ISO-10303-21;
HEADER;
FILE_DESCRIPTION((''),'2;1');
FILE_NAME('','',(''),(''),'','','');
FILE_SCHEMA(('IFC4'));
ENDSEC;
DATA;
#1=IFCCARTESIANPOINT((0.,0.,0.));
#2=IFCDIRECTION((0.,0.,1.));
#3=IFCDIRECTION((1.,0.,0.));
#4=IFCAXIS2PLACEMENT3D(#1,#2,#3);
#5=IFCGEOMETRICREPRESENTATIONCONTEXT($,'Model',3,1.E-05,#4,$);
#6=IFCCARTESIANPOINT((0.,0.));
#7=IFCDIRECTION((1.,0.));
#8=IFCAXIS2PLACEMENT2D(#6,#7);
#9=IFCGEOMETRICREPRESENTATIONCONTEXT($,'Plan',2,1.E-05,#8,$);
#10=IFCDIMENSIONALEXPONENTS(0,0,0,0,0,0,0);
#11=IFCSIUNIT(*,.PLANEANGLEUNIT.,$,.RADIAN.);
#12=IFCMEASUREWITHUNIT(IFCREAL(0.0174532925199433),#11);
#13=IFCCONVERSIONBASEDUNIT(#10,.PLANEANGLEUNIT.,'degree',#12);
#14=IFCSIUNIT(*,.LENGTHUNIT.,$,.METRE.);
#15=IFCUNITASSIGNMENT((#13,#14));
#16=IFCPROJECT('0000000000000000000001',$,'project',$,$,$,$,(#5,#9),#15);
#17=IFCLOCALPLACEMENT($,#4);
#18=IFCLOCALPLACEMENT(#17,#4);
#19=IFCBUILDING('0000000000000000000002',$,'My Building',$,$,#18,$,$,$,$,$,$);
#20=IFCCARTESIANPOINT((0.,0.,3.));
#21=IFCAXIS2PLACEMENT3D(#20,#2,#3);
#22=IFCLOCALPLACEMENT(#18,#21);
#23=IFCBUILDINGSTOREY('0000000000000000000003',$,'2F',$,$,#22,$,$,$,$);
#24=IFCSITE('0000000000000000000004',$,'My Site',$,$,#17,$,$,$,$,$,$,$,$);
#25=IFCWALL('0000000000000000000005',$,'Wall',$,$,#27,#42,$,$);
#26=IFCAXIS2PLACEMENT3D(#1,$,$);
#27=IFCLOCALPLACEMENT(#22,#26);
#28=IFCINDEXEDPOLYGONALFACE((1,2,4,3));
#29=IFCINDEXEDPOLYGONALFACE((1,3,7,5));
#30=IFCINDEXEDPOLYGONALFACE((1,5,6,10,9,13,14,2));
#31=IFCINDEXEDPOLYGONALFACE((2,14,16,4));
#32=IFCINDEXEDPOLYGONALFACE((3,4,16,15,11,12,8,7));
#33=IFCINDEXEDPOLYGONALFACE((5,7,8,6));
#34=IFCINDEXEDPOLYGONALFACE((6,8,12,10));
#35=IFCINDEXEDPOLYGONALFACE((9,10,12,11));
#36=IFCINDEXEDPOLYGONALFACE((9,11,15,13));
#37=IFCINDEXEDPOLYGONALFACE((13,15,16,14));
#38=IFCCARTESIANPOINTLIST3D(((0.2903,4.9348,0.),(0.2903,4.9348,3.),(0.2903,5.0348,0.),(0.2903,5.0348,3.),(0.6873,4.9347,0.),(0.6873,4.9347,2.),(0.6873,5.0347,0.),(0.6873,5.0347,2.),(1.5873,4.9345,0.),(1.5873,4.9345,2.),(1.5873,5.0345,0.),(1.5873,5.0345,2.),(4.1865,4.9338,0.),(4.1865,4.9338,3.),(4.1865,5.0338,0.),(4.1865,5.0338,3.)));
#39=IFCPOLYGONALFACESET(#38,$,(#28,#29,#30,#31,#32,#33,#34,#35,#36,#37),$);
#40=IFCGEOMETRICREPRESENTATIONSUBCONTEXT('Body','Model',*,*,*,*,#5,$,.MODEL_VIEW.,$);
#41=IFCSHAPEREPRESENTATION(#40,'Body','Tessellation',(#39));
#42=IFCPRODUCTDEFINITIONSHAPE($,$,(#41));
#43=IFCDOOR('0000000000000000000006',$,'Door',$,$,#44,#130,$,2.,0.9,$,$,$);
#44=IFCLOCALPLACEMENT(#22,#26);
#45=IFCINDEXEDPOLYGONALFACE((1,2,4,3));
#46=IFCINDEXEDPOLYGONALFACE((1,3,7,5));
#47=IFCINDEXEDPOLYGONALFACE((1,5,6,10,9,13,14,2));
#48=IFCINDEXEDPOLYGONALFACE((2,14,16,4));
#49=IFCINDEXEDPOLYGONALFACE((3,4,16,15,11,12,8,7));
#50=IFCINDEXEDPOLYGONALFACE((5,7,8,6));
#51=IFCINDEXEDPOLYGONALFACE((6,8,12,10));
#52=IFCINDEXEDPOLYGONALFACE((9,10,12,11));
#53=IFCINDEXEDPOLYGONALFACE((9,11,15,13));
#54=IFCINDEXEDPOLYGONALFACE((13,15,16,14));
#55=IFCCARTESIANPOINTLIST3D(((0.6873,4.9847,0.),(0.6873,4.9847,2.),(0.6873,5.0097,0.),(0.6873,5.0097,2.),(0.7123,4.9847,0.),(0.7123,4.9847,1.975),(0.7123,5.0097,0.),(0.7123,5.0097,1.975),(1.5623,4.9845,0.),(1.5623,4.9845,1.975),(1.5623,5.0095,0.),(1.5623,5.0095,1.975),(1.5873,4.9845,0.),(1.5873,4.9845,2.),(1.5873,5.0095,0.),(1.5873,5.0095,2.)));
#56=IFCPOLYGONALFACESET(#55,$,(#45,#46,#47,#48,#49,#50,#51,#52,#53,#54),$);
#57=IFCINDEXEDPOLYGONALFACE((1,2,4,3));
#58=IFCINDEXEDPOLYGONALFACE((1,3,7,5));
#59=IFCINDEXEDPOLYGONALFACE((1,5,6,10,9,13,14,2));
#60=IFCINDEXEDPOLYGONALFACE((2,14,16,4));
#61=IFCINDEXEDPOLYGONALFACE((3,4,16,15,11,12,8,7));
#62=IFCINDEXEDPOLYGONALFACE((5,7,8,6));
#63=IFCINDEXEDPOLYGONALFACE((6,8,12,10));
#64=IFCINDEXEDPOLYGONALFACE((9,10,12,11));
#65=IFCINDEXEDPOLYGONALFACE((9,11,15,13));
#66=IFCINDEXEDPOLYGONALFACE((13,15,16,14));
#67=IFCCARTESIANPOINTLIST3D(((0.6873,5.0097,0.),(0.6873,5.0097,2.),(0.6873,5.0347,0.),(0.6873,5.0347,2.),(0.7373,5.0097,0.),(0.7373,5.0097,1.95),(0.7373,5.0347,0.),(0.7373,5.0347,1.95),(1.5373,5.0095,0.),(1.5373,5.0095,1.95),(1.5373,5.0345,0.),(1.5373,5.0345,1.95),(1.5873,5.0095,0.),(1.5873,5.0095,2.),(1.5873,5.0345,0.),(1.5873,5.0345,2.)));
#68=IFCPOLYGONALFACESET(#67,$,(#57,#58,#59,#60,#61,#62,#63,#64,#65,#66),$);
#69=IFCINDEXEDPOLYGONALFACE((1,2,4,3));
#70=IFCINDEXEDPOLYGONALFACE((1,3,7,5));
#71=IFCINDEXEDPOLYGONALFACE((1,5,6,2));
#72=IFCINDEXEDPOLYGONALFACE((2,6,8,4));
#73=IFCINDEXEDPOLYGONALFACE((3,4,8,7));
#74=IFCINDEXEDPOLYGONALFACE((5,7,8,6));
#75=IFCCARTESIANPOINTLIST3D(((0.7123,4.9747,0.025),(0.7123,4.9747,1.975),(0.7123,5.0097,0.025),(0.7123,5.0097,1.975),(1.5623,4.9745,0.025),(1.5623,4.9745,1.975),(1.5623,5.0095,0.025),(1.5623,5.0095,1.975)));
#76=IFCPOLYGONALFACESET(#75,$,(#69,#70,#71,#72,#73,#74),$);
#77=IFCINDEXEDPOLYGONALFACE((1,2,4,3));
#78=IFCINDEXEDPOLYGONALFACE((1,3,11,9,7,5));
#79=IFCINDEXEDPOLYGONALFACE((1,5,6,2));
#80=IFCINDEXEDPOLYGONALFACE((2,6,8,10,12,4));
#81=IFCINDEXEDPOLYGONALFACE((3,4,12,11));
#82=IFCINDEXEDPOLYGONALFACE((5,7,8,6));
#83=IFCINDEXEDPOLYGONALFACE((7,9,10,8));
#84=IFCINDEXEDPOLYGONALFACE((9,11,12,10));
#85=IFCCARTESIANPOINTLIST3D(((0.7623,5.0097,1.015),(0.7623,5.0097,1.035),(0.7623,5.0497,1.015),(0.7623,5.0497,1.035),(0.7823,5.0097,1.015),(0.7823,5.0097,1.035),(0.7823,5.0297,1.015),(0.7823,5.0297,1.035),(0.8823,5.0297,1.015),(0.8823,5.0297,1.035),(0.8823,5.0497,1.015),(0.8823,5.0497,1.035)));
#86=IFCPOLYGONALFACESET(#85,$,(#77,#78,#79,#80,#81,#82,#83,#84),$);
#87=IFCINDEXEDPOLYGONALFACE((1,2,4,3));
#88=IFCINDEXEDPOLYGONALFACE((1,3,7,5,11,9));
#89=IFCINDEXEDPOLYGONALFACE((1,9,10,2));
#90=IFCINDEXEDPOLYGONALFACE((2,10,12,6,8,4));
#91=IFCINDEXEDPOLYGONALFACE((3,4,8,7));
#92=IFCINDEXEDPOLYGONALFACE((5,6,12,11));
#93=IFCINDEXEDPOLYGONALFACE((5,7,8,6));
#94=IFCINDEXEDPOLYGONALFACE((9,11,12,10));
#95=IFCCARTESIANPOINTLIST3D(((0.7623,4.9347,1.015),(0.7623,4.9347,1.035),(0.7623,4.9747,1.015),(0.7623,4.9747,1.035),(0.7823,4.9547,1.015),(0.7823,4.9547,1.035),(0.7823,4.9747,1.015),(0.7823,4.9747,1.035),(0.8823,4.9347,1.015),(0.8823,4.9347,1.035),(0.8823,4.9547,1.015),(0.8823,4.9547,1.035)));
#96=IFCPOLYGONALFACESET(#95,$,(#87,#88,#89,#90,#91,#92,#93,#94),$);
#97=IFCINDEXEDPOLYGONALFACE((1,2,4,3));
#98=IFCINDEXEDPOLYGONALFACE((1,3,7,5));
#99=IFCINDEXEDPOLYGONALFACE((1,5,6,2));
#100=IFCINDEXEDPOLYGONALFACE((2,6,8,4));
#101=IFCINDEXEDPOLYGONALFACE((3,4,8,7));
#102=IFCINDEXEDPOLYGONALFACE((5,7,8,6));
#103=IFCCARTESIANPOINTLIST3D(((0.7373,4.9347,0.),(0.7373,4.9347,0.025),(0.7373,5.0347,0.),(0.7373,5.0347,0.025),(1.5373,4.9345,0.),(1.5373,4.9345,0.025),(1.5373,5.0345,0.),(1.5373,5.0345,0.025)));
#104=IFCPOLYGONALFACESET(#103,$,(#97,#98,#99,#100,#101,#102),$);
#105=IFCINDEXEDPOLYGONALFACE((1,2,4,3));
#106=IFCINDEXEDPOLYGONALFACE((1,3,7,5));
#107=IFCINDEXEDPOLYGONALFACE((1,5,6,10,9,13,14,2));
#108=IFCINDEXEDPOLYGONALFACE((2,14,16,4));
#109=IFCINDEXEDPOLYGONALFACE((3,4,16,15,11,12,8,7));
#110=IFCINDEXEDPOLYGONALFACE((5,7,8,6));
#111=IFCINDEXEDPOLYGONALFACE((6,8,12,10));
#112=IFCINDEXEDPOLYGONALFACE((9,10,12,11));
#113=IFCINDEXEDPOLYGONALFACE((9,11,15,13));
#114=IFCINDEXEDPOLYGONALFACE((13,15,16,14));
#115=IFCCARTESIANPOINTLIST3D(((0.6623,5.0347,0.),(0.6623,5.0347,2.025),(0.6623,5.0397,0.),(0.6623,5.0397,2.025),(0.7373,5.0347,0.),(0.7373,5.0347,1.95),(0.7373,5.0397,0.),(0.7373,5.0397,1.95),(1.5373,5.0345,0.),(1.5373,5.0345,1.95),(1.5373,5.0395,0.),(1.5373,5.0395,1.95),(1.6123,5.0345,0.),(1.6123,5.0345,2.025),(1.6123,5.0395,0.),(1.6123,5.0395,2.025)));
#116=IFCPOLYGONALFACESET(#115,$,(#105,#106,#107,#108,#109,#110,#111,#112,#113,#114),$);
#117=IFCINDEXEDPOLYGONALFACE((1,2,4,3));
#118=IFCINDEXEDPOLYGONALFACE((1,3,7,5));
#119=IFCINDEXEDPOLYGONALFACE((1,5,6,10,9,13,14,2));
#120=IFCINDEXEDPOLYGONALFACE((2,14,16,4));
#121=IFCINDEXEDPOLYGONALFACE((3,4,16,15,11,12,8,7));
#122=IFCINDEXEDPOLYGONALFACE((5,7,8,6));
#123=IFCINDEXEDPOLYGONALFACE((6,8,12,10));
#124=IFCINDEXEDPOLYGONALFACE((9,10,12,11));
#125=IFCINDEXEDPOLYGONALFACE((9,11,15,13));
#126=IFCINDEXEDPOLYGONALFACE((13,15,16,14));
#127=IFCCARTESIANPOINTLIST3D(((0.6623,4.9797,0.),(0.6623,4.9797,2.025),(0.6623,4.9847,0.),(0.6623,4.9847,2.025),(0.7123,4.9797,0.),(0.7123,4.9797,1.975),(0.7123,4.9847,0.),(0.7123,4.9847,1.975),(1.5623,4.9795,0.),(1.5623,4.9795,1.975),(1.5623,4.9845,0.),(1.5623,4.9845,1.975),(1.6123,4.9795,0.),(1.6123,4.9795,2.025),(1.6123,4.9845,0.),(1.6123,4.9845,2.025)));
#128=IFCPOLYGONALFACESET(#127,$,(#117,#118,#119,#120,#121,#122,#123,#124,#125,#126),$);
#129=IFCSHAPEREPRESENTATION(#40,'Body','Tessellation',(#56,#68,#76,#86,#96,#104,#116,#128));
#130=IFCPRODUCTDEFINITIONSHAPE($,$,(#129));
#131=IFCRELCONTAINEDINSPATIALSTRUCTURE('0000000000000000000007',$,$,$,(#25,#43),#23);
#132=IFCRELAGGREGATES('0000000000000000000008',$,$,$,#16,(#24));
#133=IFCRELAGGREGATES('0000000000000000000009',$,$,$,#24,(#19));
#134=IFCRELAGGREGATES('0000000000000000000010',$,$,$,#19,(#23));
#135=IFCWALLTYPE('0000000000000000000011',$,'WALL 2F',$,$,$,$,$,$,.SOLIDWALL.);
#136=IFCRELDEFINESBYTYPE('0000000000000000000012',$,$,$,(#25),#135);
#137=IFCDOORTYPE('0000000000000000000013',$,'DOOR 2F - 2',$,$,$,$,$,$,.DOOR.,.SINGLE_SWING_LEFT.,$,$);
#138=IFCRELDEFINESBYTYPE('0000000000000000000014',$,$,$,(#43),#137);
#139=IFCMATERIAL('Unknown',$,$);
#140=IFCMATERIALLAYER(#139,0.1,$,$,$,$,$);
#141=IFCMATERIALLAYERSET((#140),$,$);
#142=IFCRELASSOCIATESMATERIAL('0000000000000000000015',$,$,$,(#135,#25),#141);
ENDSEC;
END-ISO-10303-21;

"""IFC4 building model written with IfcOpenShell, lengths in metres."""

from ifc_helpers import new_model, entity, si_unit, converted_unit, frame, origin_with_axes, origin_2d_with_axis, place, context, subcontext, project, spatial, line, indexed_curve, outline, extrude, shape, source, transform, mapped, material, layer, layer_set, layer_usage, type_object, type_shapes, element, fill, save


model = new_model("IFC4")

# Units and contexts
model_context = context("Model", 3, precision=1e-05, world=origin_with_axes())
plan_context = context("Plan", 2, precision=1e-05, world=origin_2d_with_axis())
body_context_1 = subcontext(model_context, "Body", "Model", "MODEL_VIEW")
body_context_2 = subcontext(plan_context, "Body", "Plan", "PLAN_VIEW")
ifc_project = project(units=[converted_unit("PLANEANGLEUNIT", "degree", entity("IfcReal", 0.0174532925199433), si_unit("PLANEANGLEUNIT", "RADIAN"), dimensions=[0, 0, 0, 0, 0, 0, 0]), si_unit("LENGTHUNIT", "METRE")], contexts=[model_context, plan_context])

# Site, building, storey
site_placement = place(None, origin_with_axes())
site = spatial("IfcSite", under=ifc_project, at=site_placement, Name="My Site")
building_placement = place(site_placement, origin_with_axes())
building = spatial("IfcBuilding", under=site, at=building_placement, Name="My Building")
storey_placement = place(building_placement, frame((0.0, 0.0, 3.0), z_axis=(0.0, 0.0, 1.0), x_axis=(1.0, 0.0, 0.0)))
storey = spatial("IfcBuildingStorey", under=building, at=storey_placement, Name="2F")

# Shared definitions
ifc_material = material(Name="Unknown")

# Shared definitions
ifc_layer_1 = layer(ifc_material, 0.1)
ifc_layer_set_1 = layer_set([ifc_layer_1])
wall_type = type_object("IfcWallType", Name="WALL 2F", PredefinedType="SOLIDWALL", material=ifc_layer_set_1)

# Shared definitions
shared_shape_1 = source(origin_with_axes(), body_context_1, "Body", "SweptSolid", [
    extrude(outline(indexed_curve([(0.0, 0.0), (0.9, 0.0), (0.9, 2.0), (0.0, 2.0)], segments=[line(1, 2, 3, 4, 1)])), frame((0.0, -0.6, 0.0), z_axis=(0.0, -1.0, 0.0), x_axis=(1.0, 0.0, 0.0)), (0.0, 0.0, -1.0), 1.2),
])
door_type_1 = type_object("IfcDoorType", Name="DOOR 2F - 2", OperationType="SINGLE_SWING_LEFT", PredefinedType="DOOR")
shared_shape_2 = source(origin_with_axes(), body_context_1, "Body", "SweptSolid", [
    extrude(outline(indexed_curve([(0.0, 0.0), (0.0, 2.0), (0.9, 2.0), (0.9, 0.0), (0.875, 0.0), (0.875, 1.975), (0.025, 1.975), (0.025, 0.0)], segments=[line(1, 2, 3, 4, 5, 6, 7, 8, 1)])), frame((0.0, 0.025, 0.0), z_axis=(0.0, -1.0, 0.0), x_axis=(1.0, 0.0, 0.0)), (0.0, 0.0, -1.0), 0.025),
    extrude(outline(indexed_curve([(0.0, 0.0), (0.0, 2.0), (0.9, 2.0), (0.9, 0.0), (0.85, 0.0), (0.85, 1.95), (0.05, 1.95), (0.05, 0.0)], segments=[line(1, 2, 3, 4, 5, 6, 7, 8, 1)])), frame((0.0, 0.0, 0.0), z_axis=(0.0, -1.0, 0.0), x_axis=(1.0, 0.0, 0.0)), (0.0, 0.0, -1.0), 0.025),
    extrude(outline(indexed_curve([(0.0, 0.0), (0.85, 0.0), (0.85, 0.035), (0.0, 0.035)], segments=[line(1, 2, 3, 4, 1)])), frame((0.025, 0.025, 0.025), z_axis=(0.0, 0.0, 1.0), x_axis=(1.0, 0.0, 0.0)), (0.0, 0.0, 1.0), 1.95),
    extrude(outline(indexed_curve([(0.0, 0.0), (0.0, -0.04), (-0.12, -0.04), (-0.12, -0.02), (-0.02, -0.02), (-0.02, 0.0)], segments=[line(1, 2, 3, 4, 5, 6, 1)])), frame((0.825, 0.025, 1.015), z_axis=(0.0, 0.0, 1.0), x_axis=(1.0, 0.0, 0.0)), (0.0, 0.0, 1.0), 0.02),
    extrude(outline(indexed_curve([(0.0, 0.0), (0.0, 0.04), (-0.12, 0.04), (-0.12, 0.02), (-0.02, 0.02), (-0.02, 0.0)], segments=[line(1, 2, 3, 4, 5, 6, 1)])), frame((0.825, 0.06, 1.015), z_axis=(0.0, 0.0, 1.0), x_axis=(1.0, 0.0, 0.0)), (0.0, 0.0, 1.0), 0.02),
    extrude(outline(indexed_curve([(0.0, 0.0), (0.8, 0.0), (0.8, 0.1), (0.0, 0.1)], segments=[line(1, 2, 3, 4, 1)])), frame((0.05, 0.0, 0.0), z_axis=(0.0, 0.0, 1.0), x_axis=(1.0, 0.0, 0.0)), (0.0, 0.0, 1.0), 0.025),
    extrude(outline(indexed_curve([(0.0, 0.0), (0.0, 2.025), (0.95, 2.025), (0.95, 0.0), (0.875, 0.0), (0.875, 1.95), (0.075, 1.95), (0.075, 0.0)], segments=[line(1, 2, 3, 4, 5, 6, 7, 8, 1)])), frame((-0.025, -0.005, 0.0), z_axis=(0.0, -1.0, 0.0), x_axis=(1.0, 0.0, 0.0)), (0.0, 0.0, -1.0), 0.005),
    extrude(outline(indexed_curve([(0.0, 0.0), (0.0, 2.025), (0.95, 2.025), (0.95, 0.0), (0.9, 0.0), (0.9, 1.975), (0.05, 1.975), (0.05, 0.0)], segments=[line(1, 2, 3, 4, 5, 6, 7, 8, 1)])), frame((-0.025, 0.05, 0.0), z_axis=(0.0, -1.0, 0.0), x_axis=(1.0, 0.0, 0.0)), (0.0, 0.0, -1.0), 0.005),
])
shared_shape_3 = source(origin_with_axes(), body_context_2, "Body", "Curve2D", [
    entity("IfcIndexedPolyCurve", entity("IfcCartesianPointList2D", [[0.0, 0.0], [0.0, 0.05], [0.025, 0.05], [0.025, 0.025], [0.05, 0.025], [0.05, 0.0]]), [entity("IfcLineIndex", [1, 2, 3, 4, 5, 6, 1])]),
    entity("IfcIndexedPolyCurve", entity("IfcCartesianPointList2D", [[0.9, 0.0], [0.9, 0.05], [0.875, 0.05], [0.875, 0.025], [0.85, 0.025], [0.85, 0.0]]), [entity("IfcLineIndex", [1, 2, 3, 4, 5, 6, 1])]),
    entity("IfcTrimmedCurve", entity("IfcEllipse", entity("IfcAxis2Placement2D", entity("IfcCartesianPoint", [0.06, 0.05]), entity("IfcDirection", [1.0, 0.0])), 0.815, 0.85), [entity("IfcCartesianPoint", [0.875, 0.05])], [entity("IfcCartesianPoint", [0.06, 0.9])], True, "CARTESIAN"),
    entity("IfcIndexedPolyCurve", entity("IfcCartesianPointList2D", [[0.025, 0.05], [0.06, 0.05], [0.06, 0.9], [0.025, 0.9]]), [entity("IfcLineIndex", [1, 2, 3, 4, 1])]),
])
type_shapes(door_type_1, [shared_shape_2, shared_shape_3])

# Wall, opening, door
ifc_layer_usage_1 = layer_usage(ifc_layer_set_1, "AXIS2", "POSITIVE", 0.0)
wall_1_placement = place(storey_placement, frame((4.1865, 5.0338, 0.0), z_axis=(0.0, 0.0, 1.0), x_axis=(-1.0, 0.000249, 0.0)))
wall_1 = element("IfcWall", 1, at=wall_1_placement, inside=storey, type_object=wall_type, material=ifc_layer_usage_1, Name="Wall", context=body_context_1, shape_type="SweptSolid", body=[
    extrude(outline(indexed_curve([(0.0, 0.0), (0.0, 0.1), (3.8962, 0.1), (3.8962, 0.0)], segments=[line(1, 2, 3, 4, 1)])), origin_with_axes(), (0.0, 0.0, 1.0), 3.0),
])
opening_1_placement = place(wall_1_placement, frame((2.5992, 0.0, 0.0), z_axis=(0.0, 0.0, 1.0), x_axis=(1.0, 0.0, 0.0)))
opening_1 = element("IfcOpeningElement", 2, at=opening_1_placement, cuts=wall_1, PredefinedType="OPENING", context=body_context_1, shape_type="MappedRepresentation", body=[
    mapped(shared_shape_1, transform((0.0, 0.0, 0.0), x_axis=(1.0, 0.0, 0.0), y_axis=(0.0, 1.0, 0.0), z_axis=(0.0, 0.0, 1.0), scale=1.0)),
])
door_1_placement = place(opening_1_placement, frame((0.0, 0.0, 0.0), z_axis=(0.0, 0.0, 1.0), x_axis=(1.0, 0.0, 0.0)))
door_1 = element("IfcDoor", 3, at=door_1_placement, inside=storey, type_object=door_type_1, Name="Door", OverallHeight=2.0, OverallWidth=0.9, shapes=[
    shape(body_context_1, "Body", "MappedRepresentation", [mapped(shared_shape_2, transform((0.0, 0.0, 0.0), x_axis=(1.0, 0.0, 0.0), y_axis=(0.0, 1.0, 0.0), z_axis=(0.0, 0.0, 1.0), scale=1.0))]),
    shape(body_context_2, "Body", "MappedRepresentation", [mapped(shared_shape_3, transform((0.0, 0.0, 0.0), x_axis=(1.0, 0.0, 0.0), y_axis=(0.0, 1.0, 0.0), z_axis=(0.0, 0.0, 1.0), scale=1.0))]),
])
fill(opening_1, door_1)

save(model, "model.ifc")
